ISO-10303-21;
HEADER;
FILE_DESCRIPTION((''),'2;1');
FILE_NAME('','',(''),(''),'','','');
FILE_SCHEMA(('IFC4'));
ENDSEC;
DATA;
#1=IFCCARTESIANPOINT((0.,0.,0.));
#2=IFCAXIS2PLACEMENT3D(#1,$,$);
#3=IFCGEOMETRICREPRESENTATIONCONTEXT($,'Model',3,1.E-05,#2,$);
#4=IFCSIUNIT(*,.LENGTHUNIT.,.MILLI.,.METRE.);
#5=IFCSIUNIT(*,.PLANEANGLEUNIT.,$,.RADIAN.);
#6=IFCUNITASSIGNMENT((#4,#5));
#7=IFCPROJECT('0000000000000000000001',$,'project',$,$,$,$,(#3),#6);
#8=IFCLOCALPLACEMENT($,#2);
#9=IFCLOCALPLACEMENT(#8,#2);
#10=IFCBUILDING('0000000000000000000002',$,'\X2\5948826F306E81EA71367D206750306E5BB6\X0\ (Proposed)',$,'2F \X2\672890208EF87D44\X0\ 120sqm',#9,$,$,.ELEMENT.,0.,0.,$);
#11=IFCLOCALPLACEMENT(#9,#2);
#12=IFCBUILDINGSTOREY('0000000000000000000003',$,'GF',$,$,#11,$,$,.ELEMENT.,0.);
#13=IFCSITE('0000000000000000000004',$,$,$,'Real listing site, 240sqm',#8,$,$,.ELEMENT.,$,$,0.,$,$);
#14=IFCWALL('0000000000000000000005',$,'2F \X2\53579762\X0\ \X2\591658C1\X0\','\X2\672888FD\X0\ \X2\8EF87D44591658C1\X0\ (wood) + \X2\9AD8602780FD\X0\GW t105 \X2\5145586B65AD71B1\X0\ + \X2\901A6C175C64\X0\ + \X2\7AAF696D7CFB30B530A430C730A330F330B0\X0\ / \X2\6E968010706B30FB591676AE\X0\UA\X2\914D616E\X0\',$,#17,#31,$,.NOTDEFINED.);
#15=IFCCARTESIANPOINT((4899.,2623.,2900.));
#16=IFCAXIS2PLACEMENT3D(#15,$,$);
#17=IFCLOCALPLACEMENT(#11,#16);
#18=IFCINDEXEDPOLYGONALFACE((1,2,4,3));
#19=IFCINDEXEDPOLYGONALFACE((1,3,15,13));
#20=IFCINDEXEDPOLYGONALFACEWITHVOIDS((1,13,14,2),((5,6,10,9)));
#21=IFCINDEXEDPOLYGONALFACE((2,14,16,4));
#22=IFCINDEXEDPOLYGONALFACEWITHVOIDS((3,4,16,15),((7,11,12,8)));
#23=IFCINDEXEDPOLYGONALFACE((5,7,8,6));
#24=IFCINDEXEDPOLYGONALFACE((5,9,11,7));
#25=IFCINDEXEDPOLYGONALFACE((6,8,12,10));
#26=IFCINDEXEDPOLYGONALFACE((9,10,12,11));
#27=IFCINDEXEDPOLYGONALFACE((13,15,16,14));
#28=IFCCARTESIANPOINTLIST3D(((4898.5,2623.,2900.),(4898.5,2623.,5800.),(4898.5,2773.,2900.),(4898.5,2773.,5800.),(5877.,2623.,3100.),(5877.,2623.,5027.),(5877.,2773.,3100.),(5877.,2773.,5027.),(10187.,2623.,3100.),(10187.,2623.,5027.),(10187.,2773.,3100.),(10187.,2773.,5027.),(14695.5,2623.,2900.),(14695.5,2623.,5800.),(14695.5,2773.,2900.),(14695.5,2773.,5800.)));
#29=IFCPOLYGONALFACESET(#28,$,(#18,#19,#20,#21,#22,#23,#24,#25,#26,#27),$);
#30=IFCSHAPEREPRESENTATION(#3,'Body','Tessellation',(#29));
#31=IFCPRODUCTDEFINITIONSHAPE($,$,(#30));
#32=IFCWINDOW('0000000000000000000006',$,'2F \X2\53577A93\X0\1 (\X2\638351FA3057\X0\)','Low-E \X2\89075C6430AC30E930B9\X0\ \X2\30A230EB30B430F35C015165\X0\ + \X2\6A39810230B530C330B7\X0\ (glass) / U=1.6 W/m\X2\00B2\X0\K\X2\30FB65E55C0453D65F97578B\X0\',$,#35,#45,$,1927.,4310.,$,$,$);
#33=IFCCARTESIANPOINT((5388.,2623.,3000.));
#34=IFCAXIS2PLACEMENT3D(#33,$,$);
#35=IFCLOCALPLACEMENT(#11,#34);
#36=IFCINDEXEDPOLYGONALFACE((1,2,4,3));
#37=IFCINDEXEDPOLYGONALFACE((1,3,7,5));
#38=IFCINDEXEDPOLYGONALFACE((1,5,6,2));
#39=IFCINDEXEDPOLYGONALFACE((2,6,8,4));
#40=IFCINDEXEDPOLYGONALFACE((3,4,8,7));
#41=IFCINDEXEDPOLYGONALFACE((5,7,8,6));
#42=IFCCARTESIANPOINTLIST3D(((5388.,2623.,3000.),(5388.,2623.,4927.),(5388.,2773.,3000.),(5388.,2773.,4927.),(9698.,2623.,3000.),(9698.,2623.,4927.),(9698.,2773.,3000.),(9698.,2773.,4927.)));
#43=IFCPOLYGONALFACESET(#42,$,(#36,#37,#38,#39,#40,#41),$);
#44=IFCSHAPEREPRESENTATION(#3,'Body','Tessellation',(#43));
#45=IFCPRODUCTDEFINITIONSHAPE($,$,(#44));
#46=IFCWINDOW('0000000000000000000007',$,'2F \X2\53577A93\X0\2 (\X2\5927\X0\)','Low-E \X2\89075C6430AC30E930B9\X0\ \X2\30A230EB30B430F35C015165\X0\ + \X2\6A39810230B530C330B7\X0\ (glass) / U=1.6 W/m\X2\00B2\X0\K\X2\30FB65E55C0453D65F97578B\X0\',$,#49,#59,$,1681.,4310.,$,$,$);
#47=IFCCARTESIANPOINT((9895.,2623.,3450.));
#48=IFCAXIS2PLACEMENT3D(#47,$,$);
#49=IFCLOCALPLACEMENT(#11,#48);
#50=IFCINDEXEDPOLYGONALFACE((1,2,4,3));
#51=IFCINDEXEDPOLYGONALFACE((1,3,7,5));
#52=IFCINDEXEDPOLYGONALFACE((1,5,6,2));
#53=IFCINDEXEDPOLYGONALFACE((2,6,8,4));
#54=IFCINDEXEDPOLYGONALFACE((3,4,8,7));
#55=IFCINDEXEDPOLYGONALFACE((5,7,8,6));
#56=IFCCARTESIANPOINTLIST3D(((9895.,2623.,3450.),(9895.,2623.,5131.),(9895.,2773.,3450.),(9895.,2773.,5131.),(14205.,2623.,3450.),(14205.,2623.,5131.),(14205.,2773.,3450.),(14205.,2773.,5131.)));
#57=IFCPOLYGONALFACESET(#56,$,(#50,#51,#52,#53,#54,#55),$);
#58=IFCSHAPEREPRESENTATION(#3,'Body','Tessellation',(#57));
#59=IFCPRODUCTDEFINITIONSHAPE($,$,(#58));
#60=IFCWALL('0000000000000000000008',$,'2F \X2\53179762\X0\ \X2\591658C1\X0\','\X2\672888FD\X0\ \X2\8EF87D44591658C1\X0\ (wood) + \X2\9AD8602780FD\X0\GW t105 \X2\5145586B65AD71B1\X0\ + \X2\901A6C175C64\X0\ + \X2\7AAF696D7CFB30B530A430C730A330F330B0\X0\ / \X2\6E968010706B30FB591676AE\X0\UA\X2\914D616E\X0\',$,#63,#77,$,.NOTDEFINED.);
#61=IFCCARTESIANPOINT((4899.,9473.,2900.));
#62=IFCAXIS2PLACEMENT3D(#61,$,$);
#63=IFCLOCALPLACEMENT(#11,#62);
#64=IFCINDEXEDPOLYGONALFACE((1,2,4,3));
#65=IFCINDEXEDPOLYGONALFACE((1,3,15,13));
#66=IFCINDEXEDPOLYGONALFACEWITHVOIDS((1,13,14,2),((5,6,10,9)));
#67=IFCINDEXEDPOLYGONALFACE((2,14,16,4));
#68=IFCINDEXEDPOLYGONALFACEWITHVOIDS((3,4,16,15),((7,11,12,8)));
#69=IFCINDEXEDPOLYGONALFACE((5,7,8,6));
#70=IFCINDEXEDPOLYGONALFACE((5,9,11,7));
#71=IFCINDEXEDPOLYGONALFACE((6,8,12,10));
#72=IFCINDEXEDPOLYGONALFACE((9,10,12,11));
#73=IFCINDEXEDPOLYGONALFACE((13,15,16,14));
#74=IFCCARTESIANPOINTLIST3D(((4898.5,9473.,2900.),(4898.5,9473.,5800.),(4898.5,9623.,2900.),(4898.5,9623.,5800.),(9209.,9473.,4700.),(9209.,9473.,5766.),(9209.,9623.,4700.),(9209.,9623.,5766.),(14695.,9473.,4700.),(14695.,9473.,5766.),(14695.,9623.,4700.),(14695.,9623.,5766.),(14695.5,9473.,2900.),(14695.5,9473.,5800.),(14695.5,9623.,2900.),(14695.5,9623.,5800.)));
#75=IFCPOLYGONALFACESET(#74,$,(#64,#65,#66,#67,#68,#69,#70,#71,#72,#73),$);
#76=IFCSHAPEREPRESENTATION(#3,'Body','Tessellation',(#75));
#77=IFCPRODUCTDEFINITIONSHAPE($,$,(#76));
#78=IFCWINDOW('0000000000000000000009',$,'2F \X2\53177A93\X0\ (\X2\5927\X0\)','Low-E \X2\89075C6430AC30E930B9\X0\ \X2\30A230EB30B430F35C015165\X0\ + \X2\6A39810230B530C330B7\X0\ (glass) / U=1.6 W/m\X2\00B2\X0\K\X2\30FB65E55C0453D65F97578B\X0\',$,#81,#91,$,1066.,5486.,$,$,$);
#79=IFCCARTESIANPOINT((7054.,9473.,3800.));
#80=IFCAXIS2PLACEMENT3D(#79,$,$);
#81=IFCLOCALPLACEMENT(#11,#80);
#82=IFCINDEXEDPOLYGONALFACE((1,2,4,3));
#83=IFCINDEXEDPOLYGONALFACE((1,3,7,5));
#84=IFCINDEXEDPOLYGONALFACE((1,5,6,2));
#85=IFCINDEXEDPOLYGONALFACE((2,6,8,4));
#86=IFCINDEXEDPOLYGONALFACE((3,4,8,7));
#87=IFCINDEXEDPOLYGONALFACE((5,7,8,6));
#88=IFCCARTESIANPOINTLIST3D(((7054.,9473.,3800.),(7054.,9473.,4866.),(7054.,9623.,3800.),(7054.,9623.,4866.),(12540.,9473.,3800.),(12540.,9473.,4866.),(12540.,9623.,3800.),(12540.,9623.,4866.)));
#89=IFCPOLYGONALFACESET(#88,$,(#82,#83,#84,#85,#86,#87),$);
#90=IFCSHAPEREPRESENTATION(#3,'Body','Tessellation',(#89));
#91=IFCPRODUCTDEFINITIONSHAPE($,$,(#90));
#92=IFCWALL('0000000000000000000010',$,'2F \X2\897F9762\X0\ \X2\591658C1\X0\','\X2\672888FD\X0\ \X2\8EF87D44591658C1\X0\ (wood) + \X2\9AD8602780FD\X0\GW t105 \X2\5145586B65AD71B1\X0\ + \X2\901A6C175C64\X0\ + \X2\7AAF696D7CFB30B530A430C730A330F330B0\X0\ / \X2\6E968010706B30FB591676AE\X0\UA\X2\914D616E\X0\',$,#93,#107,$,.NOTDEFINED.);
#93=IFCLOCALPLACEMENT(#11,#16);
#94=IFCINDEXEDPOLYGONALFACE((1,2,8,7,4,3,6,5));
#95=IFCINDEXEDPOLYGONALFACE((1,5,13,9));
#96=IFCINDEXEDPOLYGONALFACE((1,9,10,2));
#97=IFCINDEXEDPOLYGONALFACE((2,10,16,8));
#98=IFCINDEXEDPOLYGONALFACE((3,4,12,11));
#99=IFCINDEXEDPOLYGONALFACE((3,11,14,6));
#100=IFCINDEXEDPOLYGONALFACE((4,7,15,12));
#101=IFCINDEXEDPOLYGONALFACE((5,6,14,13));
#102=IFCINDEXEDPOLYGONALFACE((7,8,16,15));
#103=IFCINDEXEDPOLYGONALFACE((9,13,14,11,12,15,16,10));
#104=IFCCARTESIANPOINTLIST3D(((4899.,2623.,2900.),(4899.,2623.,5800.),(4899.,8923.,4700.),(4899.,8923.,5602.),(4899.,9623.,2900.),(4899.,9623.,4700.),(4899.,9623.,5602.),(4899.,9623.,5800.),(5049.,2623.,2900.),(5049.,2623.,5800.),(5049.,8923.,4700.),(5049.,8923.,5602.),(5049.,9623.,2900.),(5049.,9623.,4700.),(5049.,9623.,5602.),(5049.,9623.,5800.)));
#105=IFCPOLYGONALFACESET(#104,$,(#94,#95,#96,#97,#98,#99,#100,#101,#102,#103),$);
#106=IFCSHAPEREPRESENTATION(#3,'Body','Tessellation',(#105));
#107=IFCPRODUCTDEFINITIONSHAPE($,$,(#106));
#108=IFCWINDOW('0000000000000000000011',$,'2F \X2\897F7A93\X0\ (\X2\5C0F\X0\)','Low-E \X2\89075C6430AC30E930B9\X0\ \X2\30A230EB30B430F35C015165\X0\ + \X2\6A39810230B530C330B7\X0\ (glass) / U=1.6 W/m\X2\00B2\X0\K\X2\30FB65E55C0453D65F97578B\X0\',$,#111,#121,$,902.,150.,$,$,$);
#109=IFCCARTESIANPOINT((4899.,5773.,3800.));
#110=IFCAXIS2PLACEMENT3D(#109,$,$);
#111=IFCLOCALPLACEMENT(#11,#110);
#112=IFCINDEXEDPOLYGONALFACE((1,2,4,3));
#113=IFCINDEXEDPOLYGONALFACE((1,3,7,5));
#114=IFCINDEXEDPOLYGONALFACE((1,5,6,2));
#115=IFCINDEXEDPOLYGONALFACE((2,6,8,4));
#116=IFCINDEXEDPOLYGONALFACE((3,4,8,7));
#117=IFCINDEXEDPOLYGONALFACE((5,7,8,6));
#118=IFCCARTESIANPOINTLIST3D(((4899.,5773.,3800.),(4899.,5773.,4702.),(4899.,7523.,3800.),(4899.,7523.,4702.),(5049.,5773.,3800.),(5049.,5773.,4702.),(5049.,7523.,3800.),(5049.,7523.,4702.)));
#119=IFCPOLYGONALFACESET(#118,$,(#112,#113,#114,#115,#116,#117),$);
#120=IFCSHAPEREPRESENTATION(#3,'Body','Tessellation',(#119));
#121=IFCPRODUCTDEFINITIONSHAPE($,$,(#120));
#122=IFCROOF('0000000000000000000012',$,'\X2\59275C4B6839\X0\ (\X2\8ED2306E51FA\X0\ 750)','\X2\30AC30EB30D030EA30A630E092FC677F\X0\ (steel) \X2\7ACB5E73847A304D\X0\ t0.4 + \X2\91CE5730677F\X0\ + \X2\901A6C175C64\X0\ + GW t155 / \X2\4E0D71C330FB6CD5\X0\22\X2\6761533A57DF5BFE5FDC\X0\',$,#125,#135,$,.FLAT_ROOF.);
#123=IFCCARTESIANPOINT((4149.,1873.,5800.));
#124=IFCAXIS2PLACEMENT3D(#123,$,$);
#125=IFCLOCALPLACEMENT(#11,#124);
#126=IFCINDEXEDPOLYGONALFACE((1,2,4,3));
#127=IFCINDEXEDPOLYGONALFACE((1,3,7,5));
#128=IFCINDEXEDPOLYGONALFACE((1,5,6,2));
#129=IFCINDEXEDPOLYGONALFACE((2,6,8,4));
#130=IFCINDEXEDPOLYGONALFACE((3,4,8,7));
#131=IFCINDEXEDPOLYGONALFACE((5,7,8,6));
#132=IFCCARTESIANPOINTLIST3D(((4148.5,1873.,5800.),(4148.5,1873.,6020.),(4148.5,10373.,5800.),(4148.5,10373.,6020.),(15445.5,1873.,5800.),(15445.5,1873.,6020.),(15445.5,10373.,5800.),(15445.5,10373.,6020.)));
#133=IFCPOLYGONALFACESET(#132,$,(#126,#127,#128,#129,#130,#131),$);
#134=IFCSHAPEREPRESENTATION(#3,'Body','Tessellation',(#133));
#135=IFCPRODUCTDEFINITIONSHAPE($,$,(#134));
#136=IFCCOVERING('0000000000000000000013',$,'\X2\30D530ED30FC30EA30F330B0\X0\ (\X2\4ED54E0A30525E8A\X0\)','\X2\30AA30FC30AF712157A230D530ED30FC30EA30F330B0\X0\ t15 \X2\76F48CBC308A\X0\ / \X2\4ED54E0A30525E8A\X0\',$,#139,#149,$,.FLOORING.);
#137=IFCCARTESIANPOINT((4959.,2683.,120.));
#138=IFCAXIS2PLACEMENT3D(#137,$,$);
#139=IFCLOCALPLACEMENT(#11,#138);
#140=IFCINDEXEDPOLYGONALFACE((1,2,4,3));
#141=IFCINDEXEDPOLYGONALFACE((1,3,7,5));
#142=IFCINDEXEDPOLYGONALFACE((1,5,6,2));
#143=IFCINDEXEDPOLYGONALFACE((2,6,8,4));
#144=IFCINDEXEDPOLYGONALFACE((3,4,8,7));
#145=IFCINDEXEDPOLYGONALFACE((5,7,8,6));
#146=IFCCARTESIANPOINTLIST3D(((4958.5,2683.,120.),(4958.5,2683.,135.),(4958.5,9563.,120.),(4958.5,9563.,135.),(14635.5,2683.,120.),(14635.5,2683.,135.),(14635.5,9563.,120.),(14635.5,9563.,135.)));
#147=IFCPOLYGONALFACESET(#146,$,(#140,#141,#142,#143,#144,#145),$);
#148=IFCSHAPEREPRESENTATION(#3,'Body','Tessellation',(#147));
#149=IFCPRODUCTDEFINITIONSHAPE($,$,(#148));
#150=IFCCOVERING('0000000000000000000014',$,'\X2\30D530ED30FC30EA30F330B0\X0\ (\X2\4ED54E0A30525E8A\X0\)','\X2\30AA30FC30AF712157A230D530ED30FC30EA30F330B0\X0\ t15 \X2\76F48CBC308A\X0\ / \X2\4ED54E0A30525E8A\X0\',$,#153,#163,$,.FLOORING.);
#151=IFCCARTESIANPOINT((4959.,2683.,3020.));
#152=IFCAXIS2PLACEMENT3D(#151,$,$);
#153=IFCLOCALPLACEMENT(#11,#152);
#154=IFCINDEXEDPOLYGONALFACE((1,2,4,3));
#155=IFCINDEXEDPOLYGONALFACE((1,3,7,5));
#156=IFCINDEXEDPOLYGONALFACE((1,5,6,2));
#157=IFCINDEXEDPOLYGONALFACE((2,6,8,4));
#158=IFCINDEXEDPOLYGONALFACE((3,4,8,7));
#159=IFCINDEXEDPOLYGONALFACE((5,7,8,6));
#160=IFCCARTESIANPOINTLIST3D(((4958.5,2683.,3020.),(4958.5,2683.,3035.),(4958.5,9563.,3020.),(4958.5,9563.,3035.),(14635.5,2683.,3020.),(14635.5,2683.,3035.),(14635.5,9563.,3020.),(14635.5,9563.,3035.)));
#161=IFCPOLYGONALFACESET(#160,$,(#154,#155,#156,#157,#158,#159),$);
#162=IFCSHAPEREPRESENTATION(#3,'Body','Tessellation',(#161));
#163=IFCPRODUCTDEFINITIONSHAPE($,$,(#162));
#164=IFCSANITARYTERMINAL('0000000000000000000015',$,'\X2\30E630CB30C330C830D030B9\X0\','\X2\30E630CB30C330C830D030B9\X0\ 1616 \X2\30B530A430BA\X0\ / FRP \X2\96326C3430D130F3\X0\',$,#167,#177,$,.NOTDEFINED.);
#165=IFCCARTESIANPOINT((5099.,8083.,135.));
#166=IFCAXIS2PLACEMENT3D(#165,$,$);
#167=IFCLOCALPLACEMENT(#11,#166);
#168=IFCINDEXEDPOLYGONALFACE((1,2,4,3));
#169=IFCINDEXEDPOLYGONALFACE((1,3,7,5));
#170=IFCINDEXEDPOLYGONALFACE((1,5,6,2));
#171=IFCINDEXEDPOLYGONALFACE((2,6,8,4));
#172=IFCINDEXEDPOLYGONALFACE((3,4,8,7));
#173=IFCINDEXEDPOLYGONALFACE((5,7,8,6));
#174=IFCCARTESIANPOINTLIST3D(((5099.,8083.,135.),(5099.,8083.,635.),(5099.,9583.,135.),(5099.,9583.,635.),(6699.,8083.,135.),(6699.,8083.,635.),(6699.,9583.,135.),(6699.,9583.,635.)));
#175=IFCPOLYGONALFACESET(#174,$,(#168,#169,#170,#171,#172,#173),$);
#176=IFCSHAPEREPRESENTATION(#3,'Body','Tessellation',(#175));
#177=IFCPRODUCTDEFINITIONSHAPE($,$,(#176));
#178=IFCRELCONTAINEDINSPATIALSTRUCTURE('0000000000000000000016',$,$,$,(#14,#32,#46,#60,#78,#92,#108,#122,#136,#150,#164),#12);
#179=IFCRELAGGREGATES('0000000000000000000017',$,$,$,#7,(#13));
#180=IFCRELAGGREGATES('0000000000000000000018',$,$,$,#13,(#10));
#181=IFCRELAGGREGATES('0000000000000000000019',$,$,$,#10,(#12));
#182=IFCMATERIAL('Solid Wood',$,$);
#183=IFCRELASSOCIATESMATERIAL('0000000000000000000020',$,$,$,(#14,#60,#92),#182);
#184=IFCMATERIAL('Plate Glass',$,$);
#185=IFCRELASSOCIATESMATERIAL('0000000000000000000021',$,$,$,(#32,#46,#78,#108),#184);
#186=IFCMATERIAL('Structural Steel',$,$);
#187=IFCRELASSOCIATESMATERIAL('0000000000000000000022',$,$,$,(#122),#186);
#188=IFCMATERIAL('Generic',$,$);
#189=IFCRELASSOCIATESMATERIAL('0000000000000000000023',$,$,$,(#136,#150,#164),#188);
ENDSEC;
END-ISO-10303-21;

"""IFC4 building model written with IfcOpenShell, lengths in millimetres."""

from ifc_helpers import new_model, si_unit, frame, frame_2d, origin, place, context, project, spatial, rectangle, extrude, material, element, fill, save


model = new_model("IFC4")

# Units and contexts
model_context = context("Model", 3, precision=1e-05, world=origin())
ifc_project = project(units=[si_unit("LENGTHUNIT", "METRE", prefix="MILLI"), si_unit("PLANEANGLEUNIT", "RADIAN")], contexts=[model_context])

# Site, building, storey
site_placement = place(None, origin())
site = spatial("IfcSite", under=ifc_project, at=site_placement, ObjectType="Real listing site, 240sqm", CompositionType="ELEMENT", RefElevation=0.0)
building_placement = place(site_placement, origin())
building = spatial("IfcBuilding", under=site, at=building_placement, Name="奈良の自然素材の家 (Proposed)", ObjectType="2F 木造軸組 120sqm", CompositionType="ELEMENT", ElevationOfRefHeight=0.0, ElevationOfTerrain=0.0)
storey_placement = place(building_placement, origin())
storey = spatial("IfcBuildingStorey", under=building, at=storey_placement, Name="GF", CompositionType="ELEMENT", Elevation=0.0)

# Shared definitions
ifc_material_1 = material(Name="Solid Wood")

# Shared definitions
ifc_material_2 = material(Name="Plate Glass")

# Wall, openings, windows
wall_1_placement = place(storey_placement, frame((4899.0, 2623.0, 2900.0)))
wall_1 = element("IfcWall", 1, at=wall_1_placement, inside=storey, material=ifc_material_1, Name="2F 南面 外壁", Description="木製 軸組外壁 (wood) + 高性能GW t105 充填断熱 + 通気層 + 窯業系サイディング / 準耐火・外皮UA配慮", PredefinedType="NOTDEFINED", context=model_context, shape_type="SweptSolid", body=[
    extrude(rectangle(XDim=9797.0, YDim=150.0, at=frame_2d((4898.0, 75.0))), frame((4899.0, 2623.0, 2900.0)), (0.0, 0.0, 1.0), 2900.0),
])
opening_1_placement = place(storey_placement, frame((5388.0, 2623.0, 3000.0)))
opening_1 = element("IfcOpeningElement", 2, at=opening_1_placement, cuts=wall_1, PredefinedType="NOTDEFINED", context=model_context, shape_type="SweptSolid", body=[
    extrude(rectangle(XDim=4310.0, YDim=150.0, at=frame_2d((2155.0, 75.0))), frame((5388.0, 2623.0, 3000.0)), (0.0, 0.0, 1.0), 1927.0),
])
opening_2_placement = place(storey_placement, frame((9895.0, 2623.0, 3450.0)))
opening_2 = element("IfcOpeningElement", 3, at=opening_2_placement, cuts=wall_1, PredefinedType="NOTDEFINED", context=model_context, shape_type="SweptSolid", body=[
    extrude(rectangle(XDim=4310.0, YDim=150.0, at=frame_2d((2155.0, 75.0))), frame((9895.0, 2623.0, 3450.0)), (0.0, 0.0, 1.0), 1681.0),
])
window_1_placement = place(storey_placement, frame((5388.0, 2623.0, 3000.0)))
window_1 = element("IfcWindow", 4, at=window_1_placement, inside=storey, material=ifc_material_2, Name="2F 南窓1 (掃出し)", Description="Low-E 複層ガラス アルゴン封入 + 樹脂サッシ (glass) / U=1.6 W/m²K・日射取得型", OverallHeight=1927.0, OverallWidth=4310.0, context=model_context, shape_type="SweptSolid", body=[
    extrude(rectangle(XDim=4310.0, YDim=150.0, at=frame_2d((2155.0, 75.0))), frame((5388.0, 2623.0, 3000.0)), (0.0, 0.0, 1.0), 1927.0),
])
fill(opening_1, window_1)
window_2_placement = place(storey_placement, frame((9895.0, 2623.0, 3450.0)))
window_2 = element("IfcWindow", 5, at=window_2_placement, inside=storey, material=ifc_material_2, Name="2F 南窓2 (大)", Description="Low-E 複層ガラス アルゴン封入 + 樹脂サッシ (glass) / U=1.6 W/m²K・日射取得型", OverallHeight=1681.0, OverallWidth=4310.0, context=model_context, shape_type="SweptSolid", body=[
    extrude(rectangle(XDim=4310.0, YDim=150.0, at=frame_2d((2155.0, 75.0))), frame((9895.0, 2623.0, 3450.0)), (0.0, 0.0, 1.0), 1681.0),
])
fill(opening_2, window_2)

# Walls, openings, windows
wall_2_placement = place(storey_placement, frame((4899.0, 9473.0, 2900.0)))
wall_2 = element("IfcWall", 6, at=wall_2_placement, inside=storey, material=ifc_material_1, Name="2F 北面 外壁", Description="木製 軸組外壁 (wood) + 高性能GW t105 充填断熱 + 通気層 + 窯業系サイディング / 準耐火・外皮UA配慮", PredefinedType="NOTDEFINED", context=model_context, shape_type="SweptSolid", body=[
    extrude(rectangle(XDim=9797.0, YDim=150.0, at=frame_2d((4898.0, 75.0))), frame((4899.0, 9473.0, 2900.0)), (0.0, 0.0, 1.0), 2900.0),
])
opening_3_placement = place(storey_placement, frame((7054.0, 9473.0, 3800.0)))
opening_3 = element("IfcOpeningElement", 7, at=opening_3_placement, cuts=wall_2, PredefinedType="NOTDEFINED", context=model_context, shape_type="SweptSolid", body=[
    extrude(rectangle(XDim=5486.0, YDim=150.0, at=frame_2d((2743.0, 75.0))), frame((7054.0, 9473.0, 3800.0)), (0.0, 0.0, 1.0), 1066.0),
])
window_3_placement = place(storey_placement, frame((7054.0, 9473.0, 3800.0)))
window_3 = element("IfcWindow", 8, at=window_3_placement, inside=storey, material=ifc_material_2, Name="2F 北窓 (大)", Description="Low-E 複層ガラス アルゴン封入 + 樹脂サッシ (glass) / U=1.6 W/m²K・日射取得型", OverallHeight=1066.0, OverallWidth=5486.0, context=model_context, shape_type="SweptSolid", body=[
    extrude(rectangle(XDim=5486.0, YDim=150.0, at=frame_2d((2743.0, 75.0))), frame((7054.0, 9473.0, 3800.0)), (0.0, 0.0, 1.0), 1066.0),
])
fill(opening_3, window_3)
wall_3_placement = place(storey_placement, frame((4899.0, 2623.0, 2900.0)))
wall_3 = element("IfcWall", 9, at=wall_3_placement, inside=storey, material=ifc_material_1, Name="2F 西面 外壁", Description="木製 軸組外壁 (wood) + 高性能GW t105 充填断熱 + 通気層 + 窯業系サイディング / 準耐火・外皮UA配慮", PredefinedType="NOTDEFINED", context=model_context, shape_type="SweptSolid", body=[
    extrude(rectangle(XDim=150.0, YDim=7000.0, at=frame_2d((75.0, 3500.0))), frame((4899.0, 2623.0, 2900.0)), (0.0, 0.0, 1.0), 2900.0),
])
opening_4_placement = place(storey_placement, frame((4899.0, 5773.0, 3800.0)))
opening_4 = element("IfcOpeningElement", 10, at=opening_4_placement, cuts=wall_3, PredefinedType="NOTDEFINED", context=model_context, shape_type="SweptSolid", body=[
    extrude(rectangle(XDim=150.0, YDim=1750.0, at=frame_2d((75.0, 875.0))), frame((4899.0, 5773.0, 3800.0)), (0.0, 0.0, 1.0), 902.0),
])
window_4_placement = place(storey_placement, frame((4899.0, 5773.0, 3800.0)))
window_4 = element("IfcWindow", 11, at=window_4_placement, inside=storey, material=ifc_material_2, Name="2F 西窓 (小)", Description="Low-E 複層ガラス アルゴン封入 + 樹脂サッシ (glass) / U=1.6 W/m²K・日射取得型", OverallHeight=902.0, OverallWidth=150.0, context=model_context, shape_type="SweptSolid", body=[
    extrude(rectangle(XDim=150.0, YDim=1750.0, at=frame_2d((75.0, 875.0))), frame((4899.0, 5773.0, 3800.0)), (0.0, 0.0, 1.0), 902.0),
])
fill(opening_4, window_4)

# Roof
ifc_material_3 = material(Name="Structural Steel")
roof_placement = place(storey_placement, frame((4149.0, 1873.0, 5800.0)))
element("IfcRoof", 12, at=roof_placement, inside=storey, material=ifc_material_3, Name="大屋根 (軒の出 750)", Description="ガルバリウム鋼板 (steel) 立平葺き t0.4 + 野地板 + 通気層 + GW t155 / 不燃・法22条区域対応", PredefinedType="FLAT_ROOF", context=model_context, shape_type="SweptSolid", body=[
    extrude(rectangle(XDim=11297.0, YDim=8500.0, at=frame_2d((5648.0, 4250.0))), frame((4149.0, 1873.0, 5800.0)), (0.0, 0.0, 1.0), 220.0),
])

# Coverings
ifc_material_4 = material(Name="Generic")
covering_1_placement = place(storey_placement, frame((4959.0, 2683.0, 120.0)))
element("IfcCovering", 13, at=covering_1_placement, inside=storey, material=ifc_material_4, Name="フローリング (仕上げ床)", Description="オーク無垢フローリング t15 直貼り / 仕上げ床", PredefinedType="FLOORING", context=model_context, shape_type="SweptSolid", body=[
    extrude(rectangle(XDim=9677.0, YDim=6880.0, at=frame_2d((4838.0, 3440.0))), frame((4959.0, 2683.0, 120.0)), (0.0, 0.0, 1.0), 15.0),
])
covering_2_placement = place(storey_placement, frame((4959.0, 2683.0, 3020.0)))
element("IfcCovering", 14, at=covering_2_placement, inside=storey, material=ifc_material_4, Name="フローリング (仕上げ床)", Description="オーク無垢フローリング t15 直貼り / 仕上げ床", PredefinedType="FLOORING", context=model_context, shape_type="SweptSolid", body=[
    extrude(rectangle(XDim=9677.0, YDim=6880.0, at=frame_2d((4838.0, 3440.0))), frame((4959.0, 2683.0, 3020.0)), (0.0, 0.0, 1.0), 15.0),
])

# Sanitary terminal
sanitary_terminal_placement = place(storey_placement, frame((5099.0, 8083.0, 135.0)))
element("IfcSanitaryTerminal", 15, at=sanitary_terminal_placement, inside=storey, material=ifc_material_4, Name="ユニットバス", Description="ユニットバス 1616 サイズ / FRP 防水パン", PredefinedType="NOTDEFINED", context=model_context, shape_type="SweptSolid", body=[
    extrude(rectangle(XDim=1600.0, YDim=1500.0, at=frame_2d((800.0, 750.0))), frame((5099.0, 8083.0, 135.0)), (0.0, 0.0, 1.0), 500.0),
])

save(model, "model.ifc")
